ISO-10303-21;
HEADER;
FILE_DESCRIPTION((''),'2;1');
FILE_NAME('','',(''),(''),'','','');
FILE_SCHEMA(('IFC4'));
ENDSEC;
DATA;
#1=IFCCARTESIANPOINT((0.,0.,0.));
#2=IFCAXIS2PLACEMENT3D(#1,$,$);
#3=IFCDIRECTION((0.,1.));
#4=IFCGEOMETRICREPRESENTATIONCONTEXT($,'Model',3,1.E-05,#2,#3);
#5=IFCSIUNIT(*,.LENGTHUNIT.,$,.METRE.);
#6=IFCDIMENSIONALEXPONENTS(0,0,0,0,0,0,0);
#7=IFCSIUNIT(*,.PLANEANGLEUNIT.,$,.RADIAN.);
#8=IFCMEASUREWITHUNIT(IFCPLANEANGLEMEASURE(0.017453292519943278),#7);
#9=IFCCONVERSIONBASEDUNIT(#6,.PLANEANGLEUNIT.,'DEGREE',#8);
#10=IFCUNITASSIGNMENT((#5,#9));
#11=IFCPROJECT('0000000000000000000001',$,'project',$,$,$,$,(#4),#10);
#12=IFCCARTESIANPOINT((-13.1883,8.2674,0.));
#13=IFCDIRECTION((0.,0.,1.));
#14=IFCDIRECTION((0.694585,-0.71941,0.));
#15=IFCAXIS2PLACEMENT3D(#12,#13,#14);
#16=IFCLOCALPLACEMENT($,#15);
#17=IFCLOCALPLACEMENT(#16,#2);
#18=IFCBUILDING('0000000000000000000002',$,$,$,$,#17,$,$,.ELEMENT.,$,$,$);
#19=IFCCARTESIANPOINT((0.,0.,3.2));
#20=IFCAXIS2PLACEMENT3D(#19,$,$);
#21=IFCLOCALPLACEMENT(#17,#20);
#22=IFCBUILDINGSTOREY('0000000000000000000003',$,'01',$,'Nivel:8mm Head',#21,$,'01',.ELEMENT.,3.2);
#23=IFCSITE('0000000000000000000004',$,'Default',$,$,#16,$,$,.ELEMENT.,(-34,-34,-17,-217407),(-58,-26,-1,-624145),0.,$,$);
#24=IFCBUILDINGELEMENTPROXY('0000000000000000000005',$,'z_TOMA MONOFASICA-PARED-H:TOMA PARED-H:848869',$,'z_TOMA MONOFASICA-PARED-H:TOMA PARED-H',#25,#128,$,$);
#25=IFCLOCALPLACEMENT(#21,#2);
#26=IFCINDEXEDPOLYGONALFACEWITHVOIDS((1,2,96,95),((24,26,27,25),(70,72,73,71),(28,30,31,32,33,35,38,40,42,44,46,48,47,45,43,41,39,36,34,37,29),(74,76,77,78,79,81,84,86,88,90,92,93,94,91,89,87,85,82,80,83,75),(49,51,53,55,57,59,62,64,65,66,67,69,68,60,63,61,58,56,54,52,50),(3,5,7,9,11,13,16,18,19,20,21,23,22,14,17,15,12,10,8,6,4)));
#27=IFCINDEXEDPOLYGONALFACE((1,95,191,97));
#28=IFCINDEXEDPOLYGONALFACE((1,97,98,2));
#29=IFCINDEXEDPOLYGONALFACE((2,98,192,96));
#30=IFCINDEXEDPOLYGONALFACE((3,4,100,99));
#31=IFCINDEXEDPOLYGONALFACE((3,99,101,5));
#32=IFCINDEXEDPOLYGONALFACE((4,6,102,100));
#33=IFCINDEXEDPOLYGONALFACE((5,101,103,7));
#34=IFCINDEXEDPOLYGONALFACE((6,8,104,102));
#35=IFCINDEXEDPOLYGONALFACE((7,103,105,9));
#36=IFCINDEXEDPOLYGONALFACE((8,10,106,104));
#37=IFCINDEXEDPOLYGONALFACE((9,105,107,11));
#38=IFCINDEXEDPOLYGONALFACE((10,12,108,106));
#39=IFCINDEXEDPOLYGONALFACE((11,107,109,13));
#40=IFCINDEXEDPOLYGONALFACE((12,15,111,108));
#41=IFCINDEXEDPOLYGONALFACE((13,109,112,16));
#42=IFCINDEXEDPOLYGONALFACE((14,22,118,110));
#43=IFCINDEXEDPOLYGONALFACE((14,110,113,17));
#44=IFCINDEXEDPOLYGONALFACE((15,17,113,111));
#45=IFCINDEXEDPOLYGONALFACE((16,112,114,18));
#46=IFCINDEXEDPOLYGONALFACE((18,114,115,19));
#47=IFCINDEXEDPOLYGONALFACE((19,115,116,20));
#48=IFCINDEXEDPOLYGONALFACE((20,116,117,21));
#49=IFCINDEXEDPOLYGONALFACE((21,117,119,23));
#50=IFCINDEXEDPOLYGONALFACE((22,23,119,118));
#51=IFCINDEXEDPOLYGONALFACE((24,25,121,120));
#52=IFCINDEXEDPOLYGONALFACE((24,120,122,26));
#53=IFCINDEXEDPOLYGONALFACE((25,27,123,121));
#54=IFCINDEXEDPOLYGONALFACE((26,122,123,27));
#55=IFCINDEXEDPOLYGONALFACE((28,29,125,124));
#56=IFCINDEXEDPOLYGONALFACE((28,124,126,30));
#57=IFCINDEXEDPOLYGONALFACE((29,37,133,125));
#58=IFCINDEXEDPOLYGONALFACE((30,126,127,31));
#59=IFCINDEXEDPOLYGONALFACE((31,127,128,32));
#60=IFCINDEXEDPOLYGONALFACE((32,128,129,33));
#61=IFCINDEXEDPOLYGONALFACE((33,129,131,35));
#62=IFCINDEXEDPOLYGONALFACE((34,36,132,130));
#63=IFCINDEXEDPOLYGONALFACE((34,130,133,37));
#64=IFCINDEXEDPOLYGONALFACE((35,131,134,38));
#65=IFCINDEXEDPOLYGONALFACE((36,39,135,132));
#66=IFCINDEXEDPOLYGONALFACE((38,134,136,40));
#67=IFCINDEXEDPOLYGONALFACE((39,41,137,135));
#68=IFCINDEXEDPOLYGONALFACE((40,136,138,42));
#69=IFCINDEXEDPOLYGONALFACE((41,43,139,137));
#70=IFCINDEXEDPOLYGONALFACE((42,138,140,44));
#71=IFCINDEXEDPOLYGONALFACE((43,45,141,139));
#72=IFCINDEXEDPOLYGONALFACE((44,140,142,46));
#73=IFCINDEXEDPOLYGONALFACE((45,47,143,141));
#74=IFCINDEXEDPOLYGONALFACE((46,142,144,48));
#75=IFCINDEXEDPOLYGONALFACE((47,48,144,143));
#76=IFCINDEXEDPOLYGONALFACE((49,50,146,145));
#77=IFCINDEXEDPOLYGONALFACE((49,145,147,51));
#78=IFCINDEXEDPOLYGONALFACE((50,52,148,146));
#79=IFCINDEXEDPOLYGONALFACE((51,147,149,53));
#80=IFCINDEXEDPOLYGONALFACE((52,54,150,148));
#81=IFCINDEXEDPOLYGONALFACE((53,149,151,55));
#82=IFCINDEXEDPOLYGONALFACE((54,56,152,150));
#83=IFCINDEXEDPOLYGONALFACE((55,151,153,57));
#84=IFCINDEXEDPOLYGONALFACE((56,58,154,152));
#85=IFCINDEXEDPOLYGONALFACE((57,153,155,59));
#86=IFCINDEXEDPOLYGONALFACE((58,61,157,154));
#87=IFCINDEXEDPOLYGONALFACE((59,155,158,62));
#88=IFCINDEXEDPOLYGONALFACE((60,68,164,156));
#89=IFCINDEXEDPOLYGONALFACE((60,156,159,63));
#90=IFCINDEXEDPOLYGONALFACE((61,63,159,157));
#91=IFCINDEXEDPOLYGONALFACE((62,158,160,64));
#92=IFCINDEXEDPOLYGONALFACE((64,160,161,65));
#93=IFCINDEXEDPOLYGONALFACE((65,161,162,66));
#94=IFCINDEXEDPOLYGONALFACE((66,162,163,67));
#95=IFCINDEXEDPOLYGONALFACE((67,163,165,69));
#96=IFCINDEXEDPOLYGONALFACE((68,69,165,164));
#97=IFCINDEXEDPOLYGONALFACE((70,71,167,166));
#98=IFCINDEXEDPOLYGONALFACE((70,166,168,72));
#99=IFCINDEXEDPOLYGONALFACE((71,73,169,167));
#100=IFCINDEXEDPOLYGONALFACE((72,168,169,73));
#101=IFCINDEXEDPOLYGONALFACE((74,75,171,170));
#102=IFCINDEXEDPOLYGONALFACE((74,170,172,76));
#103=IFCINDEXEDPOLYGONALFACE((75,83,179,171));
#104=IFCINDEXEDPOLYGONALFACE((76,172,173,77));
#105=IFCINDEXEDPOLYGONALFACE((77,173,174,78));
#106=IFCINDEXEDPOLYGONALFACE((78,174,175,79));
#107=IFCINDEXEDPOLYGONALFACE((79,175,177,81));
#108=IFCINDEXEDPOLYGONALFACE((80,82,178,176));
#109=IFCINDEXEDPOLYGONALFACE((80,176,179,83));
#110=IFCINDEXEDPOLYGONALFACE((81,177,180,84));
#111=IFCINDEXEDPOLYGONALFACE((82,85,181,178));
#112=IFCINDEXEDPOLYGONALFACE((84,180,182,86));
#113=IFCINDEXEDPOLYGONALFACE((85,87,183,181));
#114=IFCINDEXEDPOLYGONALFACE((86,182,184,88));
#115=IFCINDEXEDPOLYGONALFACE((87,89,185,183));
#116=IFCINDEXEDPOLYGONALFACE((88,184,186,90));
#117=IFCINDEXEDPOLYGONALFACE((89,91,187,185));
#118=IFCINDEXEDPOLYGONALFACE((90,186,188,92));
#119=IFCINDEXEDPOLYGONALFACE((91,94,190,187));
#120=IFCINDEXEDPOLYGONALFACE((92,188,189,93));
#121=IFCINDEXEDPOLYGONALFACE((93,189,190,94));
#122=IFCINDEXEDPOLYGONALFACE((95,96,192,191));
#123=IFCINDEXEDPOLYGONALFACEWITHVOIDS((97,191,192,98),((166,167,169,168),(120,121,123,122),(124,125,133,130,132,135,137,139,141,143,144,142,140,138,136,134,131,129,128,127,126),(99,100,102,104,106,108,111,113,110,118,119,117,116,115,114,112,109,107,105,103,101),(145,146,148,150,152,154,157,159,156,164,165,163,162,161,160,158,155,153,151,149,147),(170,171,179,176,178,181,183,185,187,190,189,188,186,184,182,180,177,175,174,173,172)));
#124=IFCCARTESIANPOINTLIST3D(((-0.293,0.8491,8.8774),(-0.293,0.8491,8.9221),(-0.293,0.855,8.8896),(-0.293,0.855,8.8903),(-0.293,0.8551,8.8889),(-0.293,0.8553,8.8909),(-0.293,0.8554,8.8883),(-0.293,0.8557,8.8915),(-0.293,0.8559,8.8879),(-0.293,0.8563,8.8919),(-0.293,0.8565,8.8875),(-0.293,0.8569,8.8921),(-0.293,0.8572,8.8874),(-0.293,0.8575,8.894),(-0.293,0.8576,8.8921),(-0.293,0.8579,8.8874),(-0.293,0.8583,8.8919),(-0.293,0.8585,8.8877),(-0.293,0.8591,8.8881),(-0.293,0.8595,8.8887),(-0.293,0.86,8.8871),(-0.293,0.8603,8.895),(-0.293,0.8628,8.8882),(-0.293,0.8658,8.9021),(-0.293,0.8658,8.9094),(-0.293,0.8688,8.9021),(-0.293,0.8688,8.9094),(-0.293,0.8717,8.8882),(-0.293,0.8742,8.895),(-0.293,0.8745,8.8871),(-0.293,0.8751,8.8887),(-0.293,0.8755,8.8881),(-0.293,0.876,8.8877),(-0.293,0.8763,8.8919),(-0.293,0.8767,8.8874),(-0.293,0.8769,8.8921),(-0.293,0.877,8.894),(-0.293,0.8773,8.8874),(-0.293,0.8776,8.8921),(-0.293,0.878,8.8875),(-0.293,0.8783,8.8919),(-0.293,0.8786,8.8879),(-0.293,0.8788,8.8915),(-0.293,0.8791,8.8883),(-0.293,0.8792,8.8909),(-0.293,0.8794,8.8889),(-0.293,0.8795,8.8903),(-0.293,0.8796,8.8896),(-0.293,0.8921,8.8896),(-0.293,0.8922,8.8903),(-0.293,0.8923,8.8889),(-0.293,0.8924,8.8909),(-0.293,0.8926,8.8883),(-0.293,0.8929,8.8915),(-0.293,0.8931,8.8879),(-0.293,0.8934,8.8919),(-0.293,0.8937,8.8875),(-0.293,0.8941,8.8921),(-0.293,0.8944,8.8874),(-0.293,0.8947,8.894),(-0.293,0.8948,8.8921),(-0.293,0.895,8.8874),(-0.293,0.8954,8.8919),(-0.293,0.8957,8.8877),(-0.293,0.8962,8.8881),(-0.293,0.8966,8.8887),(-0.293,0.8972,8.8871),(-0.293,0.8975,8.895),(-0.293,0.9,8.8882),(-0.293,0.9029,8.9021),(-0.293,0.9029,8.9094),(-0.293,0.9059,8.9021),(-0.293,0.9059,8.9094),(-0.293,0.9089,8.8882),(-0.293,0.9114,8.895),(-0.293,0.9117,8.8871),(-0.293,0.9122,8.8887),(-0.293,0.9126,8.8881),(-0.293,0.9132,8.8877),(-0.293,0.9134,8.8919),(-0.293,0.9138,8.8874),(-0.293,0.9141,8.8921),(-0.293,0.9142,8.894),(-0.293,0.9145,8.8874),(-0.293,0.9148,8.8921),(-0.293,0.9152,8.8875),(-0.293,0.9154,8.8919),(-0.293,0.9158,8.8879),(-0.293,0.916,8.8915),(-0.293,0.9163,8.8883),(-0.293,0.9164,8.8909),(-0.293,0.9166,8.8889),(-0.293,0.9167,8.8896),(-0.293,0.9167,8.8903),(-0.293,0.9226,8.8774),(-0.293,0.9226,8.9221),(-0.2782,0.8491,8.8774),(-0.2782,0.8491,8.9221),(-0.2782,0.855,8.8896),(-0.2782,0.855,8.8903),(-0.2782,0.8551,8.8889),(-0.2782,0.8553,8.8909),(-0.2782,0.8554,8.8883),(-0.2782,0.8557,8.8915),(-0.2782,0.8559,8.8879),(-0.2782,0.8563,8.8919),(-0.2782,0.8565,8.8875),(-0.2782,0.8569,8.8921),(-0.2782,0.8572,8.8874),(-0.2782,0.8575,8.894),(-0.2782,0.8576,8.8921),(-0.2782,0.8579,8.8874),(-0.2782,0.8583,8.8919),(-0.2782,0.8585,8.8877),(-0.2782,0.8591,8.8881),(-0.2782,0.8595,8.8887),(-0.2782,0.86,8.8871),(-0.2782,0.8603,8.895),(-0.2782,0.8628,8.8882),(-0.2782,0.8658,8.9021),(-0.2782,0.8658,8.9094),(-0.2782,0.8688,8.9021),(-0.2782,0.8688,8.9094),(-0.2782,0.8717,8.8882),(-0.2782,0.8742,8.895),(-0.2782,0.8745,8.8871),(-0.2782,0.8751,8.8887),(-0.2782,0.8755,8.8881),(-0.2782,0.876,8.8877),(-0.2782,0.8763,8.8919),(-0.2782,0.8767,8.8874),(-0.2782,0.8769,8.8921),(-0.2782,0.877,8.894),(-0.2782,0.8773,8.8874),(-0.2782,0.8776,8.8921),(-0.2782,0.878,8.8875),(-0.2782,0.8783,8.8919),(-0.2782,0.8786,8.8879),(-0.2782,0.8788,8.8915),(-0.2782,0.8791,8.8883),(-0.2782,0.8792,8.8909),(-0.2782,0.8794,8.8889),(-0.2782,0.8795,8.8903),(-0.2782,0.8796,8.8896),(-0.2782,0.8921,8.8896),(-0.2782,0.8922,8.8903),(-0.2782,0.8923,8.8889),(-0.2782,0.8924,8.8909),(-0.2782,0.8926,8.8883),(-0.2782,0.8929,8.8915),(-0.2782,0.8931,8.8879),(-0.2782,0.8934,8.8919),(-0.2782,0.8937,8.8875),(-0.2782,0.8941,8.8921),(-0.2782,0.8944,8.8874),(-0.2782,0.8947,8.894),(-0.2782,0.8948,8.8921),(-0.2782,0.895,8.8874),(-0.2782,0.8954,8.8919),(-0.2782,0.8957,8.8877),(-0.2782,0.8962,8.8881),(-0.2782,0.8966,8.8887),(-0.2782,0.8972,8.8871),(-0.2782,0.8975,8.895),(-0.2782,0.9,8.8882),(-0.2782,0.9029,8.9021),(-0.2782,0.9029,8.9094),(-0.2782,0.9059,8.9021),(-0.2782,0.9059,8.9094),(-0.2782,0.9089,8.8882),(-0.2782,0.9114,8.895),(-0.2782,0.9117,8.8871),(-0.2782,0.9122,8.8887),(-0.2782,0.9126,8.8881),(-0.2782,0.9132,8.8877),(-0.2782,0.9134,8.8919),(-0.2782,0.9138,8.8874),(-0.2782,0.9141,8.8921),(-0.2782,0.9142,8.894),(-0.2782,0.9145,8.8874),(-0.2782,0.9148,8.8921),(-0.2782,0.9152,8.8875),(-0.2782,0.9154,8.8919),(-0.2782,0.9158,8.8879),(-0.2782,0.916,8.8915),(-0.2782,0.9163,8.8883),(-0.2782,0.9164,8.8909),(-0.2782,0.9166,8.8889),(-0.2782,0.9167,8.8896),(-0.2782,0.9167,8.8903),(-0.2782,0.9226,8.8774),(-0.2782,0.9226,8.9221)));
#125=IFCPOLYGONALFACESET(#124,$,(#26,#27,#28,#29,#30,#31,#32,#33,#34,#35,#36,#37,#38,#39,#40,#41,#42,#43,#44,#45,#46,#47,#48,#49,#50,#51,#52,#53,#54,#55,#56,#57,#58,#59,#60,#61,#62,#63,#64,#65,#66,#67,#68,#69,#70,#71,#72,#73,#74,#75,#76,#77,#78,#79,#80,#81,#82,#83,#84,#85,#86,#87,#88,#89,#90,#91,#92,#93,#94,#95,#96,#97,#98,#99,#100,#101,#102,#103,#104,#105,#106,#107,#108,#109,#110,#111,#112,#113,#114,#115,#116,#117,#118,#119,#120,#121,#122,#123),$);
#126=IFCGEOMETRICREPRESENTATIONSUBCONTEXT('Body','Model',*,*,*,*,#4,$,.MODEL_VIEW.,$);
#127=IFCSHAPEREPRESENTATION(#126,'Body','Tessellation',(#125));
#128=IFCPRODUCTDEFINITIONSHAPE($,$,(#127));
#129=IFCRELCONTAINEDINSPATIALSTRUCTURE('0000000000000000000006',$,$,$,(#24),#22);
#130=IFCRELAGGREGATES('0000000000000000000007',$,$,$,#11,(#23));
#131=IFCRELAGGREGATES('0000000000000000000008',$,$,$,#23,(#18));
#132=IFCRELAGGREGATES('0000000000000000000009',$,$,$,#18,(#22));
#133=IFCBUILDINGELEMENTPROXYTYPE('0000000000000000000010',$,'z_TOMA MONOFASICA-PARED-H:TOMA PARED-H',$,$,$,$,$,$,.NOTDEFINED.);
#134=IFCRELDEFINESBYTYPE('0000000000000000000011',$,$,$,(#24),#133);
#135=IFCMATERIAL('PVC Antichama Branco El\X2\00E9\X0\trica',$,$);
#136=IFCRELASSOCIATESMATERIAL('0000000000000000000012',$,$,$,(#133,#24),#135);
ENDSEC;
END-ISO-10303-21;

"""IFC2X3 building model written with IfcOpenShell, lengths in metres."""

from ifc_helpers import new_model, entity, si_unit, converted_unit, direction, frame, frame_2d, origin, place, context, subcontext, project, spatial, polyline, circle_curve, parameter, trimmed, segment, composite_curve, outline, extrude, source, transform, mapped, material, type_object, type_shapes, element, save


model = new_model("IFC2X3")

# Units and contexts
model_context = context("Model", 3, precision=1e-05, world=origin(), true_north=direction((0.0, 1.0)))
body_context = subcontext(model_context, "Body", "Model", "MODEL_VIEW")
ifc_project = project(units=[si_unit("LENGTHUNIT", "METRE"), converted_unit("PLANEANGLEUNIT", "DEGREE", entity("IfcPlaneAngleMeasure", 0.017453292519943278), si_unit("PLANEANGLEUNIT", "RADIAN"), dimensions=[0, 0, 0, 0, 0, 0, 0])], contexts=[model_context])

# Site, building, storey
site_placement = place(None, frame((-13.1883, 8.2674, 0.0), z_axis=(0.0, 0.0, 1.0), x_axis=(0.694585, -0.71941, 0.0)))
site = spatial("IfcSite", under=ifc_project, at=site_placement, Name="Default", CompositionType="ELEMENT", RefLatitude=(-34, -34, -17, -217407), RefLongitude=(-58, -26, -1, -624145), RefElevation=0.0)
building_placement = place(site_placement, origin())
building = spatial("IfcBuilding", under=site, at=building_placement, CompositionType="ELEMENT")
storey_placement = place(building_placement, frame((0.0, 0.0, 3.2)))
storey = spatial("IfcBuildingStorey", under=building, at=storey_placement, Name="01", ObjectType="Nivel:8mm Head", LongName="01", CompositionType="ELEMENT", Elevation=3.2)

# Building element proxy
ifc_material_1 = material(Name="PVC Antichama Branco Elétrica")
building_element_proxy_type_1 = type_object("IfcBuildingElementProxyType", Name="z_TOMA MONOFASICA-PARED-H:TOMA PARED-H", PredefinedType="NOTDEFINED", material=ifc_material_1)
shared_shape_1 = source(origin(), body_context, "Body", "SweptSolid", [
    extrude(outline(polyline([(-0.0368, -0.0223), (0.0368, -0.0223), (0.0368, 0.0223), (-0.0368, 0.0223), (-0.0368, -0.0223)]), holes=[composite_curve([segment(polyline([(0.0141, 0.0115), (0.0116, 0.0047)]), True, "CONTINUOUS"), segment(polyline([(0.0116, 0.0047), (0.0088, 0.0057)]), True, "CONTINUOUS"), segment(polyline([(0.0088, 0.0057), (0.0096, 0.0078)]), True, "CONTINUOUS"), segment(trimmed(circle_curve(frame_2d((0.0087, 0.0099), x_axis=(1.0, 0.0)), 0.0024), [parameter(27.118901)], [parameter(292.881099)], True, "PARAMETER"), False, "CONTINUOUS"), segment(polyline([(0.0108, 0.011), (0.0113, 0.0126)]), True, "CONTINUOUS"), segment(polyline([(0.0113, 0.0126), (0.0141, 0.0115)]), True, "CONTINUOUS")], self_intersect=False), composite_curve([segment(polyline([(0.0255, 0.0047), (0.023, 0.0115)]), True, "CONTINUOUS"), segment(polyline([(0.023, 0.0115), (0.0258, 0.0126)]), True, "CONTINUOUS"), segment(polyline([(0.0258, 0.0126), (0.0264, 0.011)]), True, "CONTINUOUS"), segment(trimmed(circle_curve(frame_2d((0.0285, 0.0099), x_axis=(1.0, 0.0)), 0.0024), [parameter(247.118901)], [parameter(152.881099)], True, "PARAMETER"), False, "CONTINUOUS"), segment(polyline([(0.0276, 0.0078), (0.0283, 0.0057)]), True, "CONTINUOUS"), segment(polyline([(0.0283, 0.0057), (0.0255, 0.0047)]), True, "CONTINUOUS")], self_intersect=False), polyline([(0.0201, -0.0024), (0.0201, -0.0097), (0.0171, -0.0097), (0.0171, -0.0024), (0.0201, -0.0024)]), composite_curve([segment(polyline([(-0.0141, 0.0115), (-0.0113, 0.0126)]), True, "CONTINUOUS"), segment(polyline([(-0.0113, 0.0126), (-0.0108, 0.011)]), True, "CONTINUOUS"), segment(trimmed(circle_curve(frame_2d((-0.0087, 0.0099), x_axis=(1.0, 0.0)), 0.0024), [parameter(247.118901)], [parameter(152.881099)], True, "PARAMETER"), False, "CONTINUOUS"), segment(polyline([(-0.0096, 0.0078), (-0.0088, 0.0057)]), True, "CONTINUOUS"), segment(polyline([(-0.0088, 0.0057), (-0.0116, 0.0047)]), True, "CONTINUOUS"), segment(polyline([(-0.0116, 0.0047), (-0.0141, 0.0115)]), True, "CONTINUOUS")], self_intersect=False), composite_curve([segment(polyline([(-0.0255, 0.0047), (-0.0283, 0.0057)]), True, "CONTINUOUS"), segment(polyline([(-0.0283, 0.0057), (-0.0276, 0.0078)]), True, "CONTINUOUS"), segment(trimmed(circle_curve(frame_2d((-0.0285, 0.0099), x_axis=(1.0, 0.0)), 0.0024), [parameter(27.118901)], [parameter(292.881099)], True, "PARAMETER"), False, "CONTINUOUS"), segment(polyline([(-0.0264, 0.011), (-0.0258, 0.0126)]), True, "CONTINUOUS"), segment(polyline([(-0.0258, 0.0126), (-0.023, 0.0115)]), True, "CONTINUOUS"), segment(polyline([(-0.023, 0.0115), (-0.0255, 0.0047)]), True, "CONTINUOUS")], self_intersect=False), polyline([(-0.0201, -0.0024), (-0.0171, -0.0024), (-0.0171, -0.0097), (-0.0201, -0.0097), (-0.0201, -0.0024)])]), frame((0.0, -0.005, 0.0223), z_axis=(0.0, 1.0, 0.0), x_axis=(1.0, 0.0, 0.0)), (0.0, 0.0, 1.0), 0.0148),
])
type_shapes(building_element_proxy_type_1, [shared_shape_1])
for number, where, z_axis, x_axis, name in (
    (1, (-0.288, 0.8858, 8.8774), (0.0, 0.0, 1.0), (0.0, -1.0, 0.0), "z_TOMA MONOFASICA-PARED-H:TOMA PARED-H:848869"),
):
    element("IfcBuildingElementProxy", number, at=place(storey_placement, frame(where, z_axis=z_axis, x_axis=x_axis)), inside=storey, type_object=building_element_proxy_type_1, material=ifc_material_1, Name=name, ObjectType="z_TOMA MONOFASICA-PARED-H:TOMA PARED-H", context=body_context, shape_type="MappedRepresentation", body=[
        mapped(shared_shape_1, transform((0.0, 0.0, 0.0), scale=1.0)),
    ])

save(model, "model.ifc")
